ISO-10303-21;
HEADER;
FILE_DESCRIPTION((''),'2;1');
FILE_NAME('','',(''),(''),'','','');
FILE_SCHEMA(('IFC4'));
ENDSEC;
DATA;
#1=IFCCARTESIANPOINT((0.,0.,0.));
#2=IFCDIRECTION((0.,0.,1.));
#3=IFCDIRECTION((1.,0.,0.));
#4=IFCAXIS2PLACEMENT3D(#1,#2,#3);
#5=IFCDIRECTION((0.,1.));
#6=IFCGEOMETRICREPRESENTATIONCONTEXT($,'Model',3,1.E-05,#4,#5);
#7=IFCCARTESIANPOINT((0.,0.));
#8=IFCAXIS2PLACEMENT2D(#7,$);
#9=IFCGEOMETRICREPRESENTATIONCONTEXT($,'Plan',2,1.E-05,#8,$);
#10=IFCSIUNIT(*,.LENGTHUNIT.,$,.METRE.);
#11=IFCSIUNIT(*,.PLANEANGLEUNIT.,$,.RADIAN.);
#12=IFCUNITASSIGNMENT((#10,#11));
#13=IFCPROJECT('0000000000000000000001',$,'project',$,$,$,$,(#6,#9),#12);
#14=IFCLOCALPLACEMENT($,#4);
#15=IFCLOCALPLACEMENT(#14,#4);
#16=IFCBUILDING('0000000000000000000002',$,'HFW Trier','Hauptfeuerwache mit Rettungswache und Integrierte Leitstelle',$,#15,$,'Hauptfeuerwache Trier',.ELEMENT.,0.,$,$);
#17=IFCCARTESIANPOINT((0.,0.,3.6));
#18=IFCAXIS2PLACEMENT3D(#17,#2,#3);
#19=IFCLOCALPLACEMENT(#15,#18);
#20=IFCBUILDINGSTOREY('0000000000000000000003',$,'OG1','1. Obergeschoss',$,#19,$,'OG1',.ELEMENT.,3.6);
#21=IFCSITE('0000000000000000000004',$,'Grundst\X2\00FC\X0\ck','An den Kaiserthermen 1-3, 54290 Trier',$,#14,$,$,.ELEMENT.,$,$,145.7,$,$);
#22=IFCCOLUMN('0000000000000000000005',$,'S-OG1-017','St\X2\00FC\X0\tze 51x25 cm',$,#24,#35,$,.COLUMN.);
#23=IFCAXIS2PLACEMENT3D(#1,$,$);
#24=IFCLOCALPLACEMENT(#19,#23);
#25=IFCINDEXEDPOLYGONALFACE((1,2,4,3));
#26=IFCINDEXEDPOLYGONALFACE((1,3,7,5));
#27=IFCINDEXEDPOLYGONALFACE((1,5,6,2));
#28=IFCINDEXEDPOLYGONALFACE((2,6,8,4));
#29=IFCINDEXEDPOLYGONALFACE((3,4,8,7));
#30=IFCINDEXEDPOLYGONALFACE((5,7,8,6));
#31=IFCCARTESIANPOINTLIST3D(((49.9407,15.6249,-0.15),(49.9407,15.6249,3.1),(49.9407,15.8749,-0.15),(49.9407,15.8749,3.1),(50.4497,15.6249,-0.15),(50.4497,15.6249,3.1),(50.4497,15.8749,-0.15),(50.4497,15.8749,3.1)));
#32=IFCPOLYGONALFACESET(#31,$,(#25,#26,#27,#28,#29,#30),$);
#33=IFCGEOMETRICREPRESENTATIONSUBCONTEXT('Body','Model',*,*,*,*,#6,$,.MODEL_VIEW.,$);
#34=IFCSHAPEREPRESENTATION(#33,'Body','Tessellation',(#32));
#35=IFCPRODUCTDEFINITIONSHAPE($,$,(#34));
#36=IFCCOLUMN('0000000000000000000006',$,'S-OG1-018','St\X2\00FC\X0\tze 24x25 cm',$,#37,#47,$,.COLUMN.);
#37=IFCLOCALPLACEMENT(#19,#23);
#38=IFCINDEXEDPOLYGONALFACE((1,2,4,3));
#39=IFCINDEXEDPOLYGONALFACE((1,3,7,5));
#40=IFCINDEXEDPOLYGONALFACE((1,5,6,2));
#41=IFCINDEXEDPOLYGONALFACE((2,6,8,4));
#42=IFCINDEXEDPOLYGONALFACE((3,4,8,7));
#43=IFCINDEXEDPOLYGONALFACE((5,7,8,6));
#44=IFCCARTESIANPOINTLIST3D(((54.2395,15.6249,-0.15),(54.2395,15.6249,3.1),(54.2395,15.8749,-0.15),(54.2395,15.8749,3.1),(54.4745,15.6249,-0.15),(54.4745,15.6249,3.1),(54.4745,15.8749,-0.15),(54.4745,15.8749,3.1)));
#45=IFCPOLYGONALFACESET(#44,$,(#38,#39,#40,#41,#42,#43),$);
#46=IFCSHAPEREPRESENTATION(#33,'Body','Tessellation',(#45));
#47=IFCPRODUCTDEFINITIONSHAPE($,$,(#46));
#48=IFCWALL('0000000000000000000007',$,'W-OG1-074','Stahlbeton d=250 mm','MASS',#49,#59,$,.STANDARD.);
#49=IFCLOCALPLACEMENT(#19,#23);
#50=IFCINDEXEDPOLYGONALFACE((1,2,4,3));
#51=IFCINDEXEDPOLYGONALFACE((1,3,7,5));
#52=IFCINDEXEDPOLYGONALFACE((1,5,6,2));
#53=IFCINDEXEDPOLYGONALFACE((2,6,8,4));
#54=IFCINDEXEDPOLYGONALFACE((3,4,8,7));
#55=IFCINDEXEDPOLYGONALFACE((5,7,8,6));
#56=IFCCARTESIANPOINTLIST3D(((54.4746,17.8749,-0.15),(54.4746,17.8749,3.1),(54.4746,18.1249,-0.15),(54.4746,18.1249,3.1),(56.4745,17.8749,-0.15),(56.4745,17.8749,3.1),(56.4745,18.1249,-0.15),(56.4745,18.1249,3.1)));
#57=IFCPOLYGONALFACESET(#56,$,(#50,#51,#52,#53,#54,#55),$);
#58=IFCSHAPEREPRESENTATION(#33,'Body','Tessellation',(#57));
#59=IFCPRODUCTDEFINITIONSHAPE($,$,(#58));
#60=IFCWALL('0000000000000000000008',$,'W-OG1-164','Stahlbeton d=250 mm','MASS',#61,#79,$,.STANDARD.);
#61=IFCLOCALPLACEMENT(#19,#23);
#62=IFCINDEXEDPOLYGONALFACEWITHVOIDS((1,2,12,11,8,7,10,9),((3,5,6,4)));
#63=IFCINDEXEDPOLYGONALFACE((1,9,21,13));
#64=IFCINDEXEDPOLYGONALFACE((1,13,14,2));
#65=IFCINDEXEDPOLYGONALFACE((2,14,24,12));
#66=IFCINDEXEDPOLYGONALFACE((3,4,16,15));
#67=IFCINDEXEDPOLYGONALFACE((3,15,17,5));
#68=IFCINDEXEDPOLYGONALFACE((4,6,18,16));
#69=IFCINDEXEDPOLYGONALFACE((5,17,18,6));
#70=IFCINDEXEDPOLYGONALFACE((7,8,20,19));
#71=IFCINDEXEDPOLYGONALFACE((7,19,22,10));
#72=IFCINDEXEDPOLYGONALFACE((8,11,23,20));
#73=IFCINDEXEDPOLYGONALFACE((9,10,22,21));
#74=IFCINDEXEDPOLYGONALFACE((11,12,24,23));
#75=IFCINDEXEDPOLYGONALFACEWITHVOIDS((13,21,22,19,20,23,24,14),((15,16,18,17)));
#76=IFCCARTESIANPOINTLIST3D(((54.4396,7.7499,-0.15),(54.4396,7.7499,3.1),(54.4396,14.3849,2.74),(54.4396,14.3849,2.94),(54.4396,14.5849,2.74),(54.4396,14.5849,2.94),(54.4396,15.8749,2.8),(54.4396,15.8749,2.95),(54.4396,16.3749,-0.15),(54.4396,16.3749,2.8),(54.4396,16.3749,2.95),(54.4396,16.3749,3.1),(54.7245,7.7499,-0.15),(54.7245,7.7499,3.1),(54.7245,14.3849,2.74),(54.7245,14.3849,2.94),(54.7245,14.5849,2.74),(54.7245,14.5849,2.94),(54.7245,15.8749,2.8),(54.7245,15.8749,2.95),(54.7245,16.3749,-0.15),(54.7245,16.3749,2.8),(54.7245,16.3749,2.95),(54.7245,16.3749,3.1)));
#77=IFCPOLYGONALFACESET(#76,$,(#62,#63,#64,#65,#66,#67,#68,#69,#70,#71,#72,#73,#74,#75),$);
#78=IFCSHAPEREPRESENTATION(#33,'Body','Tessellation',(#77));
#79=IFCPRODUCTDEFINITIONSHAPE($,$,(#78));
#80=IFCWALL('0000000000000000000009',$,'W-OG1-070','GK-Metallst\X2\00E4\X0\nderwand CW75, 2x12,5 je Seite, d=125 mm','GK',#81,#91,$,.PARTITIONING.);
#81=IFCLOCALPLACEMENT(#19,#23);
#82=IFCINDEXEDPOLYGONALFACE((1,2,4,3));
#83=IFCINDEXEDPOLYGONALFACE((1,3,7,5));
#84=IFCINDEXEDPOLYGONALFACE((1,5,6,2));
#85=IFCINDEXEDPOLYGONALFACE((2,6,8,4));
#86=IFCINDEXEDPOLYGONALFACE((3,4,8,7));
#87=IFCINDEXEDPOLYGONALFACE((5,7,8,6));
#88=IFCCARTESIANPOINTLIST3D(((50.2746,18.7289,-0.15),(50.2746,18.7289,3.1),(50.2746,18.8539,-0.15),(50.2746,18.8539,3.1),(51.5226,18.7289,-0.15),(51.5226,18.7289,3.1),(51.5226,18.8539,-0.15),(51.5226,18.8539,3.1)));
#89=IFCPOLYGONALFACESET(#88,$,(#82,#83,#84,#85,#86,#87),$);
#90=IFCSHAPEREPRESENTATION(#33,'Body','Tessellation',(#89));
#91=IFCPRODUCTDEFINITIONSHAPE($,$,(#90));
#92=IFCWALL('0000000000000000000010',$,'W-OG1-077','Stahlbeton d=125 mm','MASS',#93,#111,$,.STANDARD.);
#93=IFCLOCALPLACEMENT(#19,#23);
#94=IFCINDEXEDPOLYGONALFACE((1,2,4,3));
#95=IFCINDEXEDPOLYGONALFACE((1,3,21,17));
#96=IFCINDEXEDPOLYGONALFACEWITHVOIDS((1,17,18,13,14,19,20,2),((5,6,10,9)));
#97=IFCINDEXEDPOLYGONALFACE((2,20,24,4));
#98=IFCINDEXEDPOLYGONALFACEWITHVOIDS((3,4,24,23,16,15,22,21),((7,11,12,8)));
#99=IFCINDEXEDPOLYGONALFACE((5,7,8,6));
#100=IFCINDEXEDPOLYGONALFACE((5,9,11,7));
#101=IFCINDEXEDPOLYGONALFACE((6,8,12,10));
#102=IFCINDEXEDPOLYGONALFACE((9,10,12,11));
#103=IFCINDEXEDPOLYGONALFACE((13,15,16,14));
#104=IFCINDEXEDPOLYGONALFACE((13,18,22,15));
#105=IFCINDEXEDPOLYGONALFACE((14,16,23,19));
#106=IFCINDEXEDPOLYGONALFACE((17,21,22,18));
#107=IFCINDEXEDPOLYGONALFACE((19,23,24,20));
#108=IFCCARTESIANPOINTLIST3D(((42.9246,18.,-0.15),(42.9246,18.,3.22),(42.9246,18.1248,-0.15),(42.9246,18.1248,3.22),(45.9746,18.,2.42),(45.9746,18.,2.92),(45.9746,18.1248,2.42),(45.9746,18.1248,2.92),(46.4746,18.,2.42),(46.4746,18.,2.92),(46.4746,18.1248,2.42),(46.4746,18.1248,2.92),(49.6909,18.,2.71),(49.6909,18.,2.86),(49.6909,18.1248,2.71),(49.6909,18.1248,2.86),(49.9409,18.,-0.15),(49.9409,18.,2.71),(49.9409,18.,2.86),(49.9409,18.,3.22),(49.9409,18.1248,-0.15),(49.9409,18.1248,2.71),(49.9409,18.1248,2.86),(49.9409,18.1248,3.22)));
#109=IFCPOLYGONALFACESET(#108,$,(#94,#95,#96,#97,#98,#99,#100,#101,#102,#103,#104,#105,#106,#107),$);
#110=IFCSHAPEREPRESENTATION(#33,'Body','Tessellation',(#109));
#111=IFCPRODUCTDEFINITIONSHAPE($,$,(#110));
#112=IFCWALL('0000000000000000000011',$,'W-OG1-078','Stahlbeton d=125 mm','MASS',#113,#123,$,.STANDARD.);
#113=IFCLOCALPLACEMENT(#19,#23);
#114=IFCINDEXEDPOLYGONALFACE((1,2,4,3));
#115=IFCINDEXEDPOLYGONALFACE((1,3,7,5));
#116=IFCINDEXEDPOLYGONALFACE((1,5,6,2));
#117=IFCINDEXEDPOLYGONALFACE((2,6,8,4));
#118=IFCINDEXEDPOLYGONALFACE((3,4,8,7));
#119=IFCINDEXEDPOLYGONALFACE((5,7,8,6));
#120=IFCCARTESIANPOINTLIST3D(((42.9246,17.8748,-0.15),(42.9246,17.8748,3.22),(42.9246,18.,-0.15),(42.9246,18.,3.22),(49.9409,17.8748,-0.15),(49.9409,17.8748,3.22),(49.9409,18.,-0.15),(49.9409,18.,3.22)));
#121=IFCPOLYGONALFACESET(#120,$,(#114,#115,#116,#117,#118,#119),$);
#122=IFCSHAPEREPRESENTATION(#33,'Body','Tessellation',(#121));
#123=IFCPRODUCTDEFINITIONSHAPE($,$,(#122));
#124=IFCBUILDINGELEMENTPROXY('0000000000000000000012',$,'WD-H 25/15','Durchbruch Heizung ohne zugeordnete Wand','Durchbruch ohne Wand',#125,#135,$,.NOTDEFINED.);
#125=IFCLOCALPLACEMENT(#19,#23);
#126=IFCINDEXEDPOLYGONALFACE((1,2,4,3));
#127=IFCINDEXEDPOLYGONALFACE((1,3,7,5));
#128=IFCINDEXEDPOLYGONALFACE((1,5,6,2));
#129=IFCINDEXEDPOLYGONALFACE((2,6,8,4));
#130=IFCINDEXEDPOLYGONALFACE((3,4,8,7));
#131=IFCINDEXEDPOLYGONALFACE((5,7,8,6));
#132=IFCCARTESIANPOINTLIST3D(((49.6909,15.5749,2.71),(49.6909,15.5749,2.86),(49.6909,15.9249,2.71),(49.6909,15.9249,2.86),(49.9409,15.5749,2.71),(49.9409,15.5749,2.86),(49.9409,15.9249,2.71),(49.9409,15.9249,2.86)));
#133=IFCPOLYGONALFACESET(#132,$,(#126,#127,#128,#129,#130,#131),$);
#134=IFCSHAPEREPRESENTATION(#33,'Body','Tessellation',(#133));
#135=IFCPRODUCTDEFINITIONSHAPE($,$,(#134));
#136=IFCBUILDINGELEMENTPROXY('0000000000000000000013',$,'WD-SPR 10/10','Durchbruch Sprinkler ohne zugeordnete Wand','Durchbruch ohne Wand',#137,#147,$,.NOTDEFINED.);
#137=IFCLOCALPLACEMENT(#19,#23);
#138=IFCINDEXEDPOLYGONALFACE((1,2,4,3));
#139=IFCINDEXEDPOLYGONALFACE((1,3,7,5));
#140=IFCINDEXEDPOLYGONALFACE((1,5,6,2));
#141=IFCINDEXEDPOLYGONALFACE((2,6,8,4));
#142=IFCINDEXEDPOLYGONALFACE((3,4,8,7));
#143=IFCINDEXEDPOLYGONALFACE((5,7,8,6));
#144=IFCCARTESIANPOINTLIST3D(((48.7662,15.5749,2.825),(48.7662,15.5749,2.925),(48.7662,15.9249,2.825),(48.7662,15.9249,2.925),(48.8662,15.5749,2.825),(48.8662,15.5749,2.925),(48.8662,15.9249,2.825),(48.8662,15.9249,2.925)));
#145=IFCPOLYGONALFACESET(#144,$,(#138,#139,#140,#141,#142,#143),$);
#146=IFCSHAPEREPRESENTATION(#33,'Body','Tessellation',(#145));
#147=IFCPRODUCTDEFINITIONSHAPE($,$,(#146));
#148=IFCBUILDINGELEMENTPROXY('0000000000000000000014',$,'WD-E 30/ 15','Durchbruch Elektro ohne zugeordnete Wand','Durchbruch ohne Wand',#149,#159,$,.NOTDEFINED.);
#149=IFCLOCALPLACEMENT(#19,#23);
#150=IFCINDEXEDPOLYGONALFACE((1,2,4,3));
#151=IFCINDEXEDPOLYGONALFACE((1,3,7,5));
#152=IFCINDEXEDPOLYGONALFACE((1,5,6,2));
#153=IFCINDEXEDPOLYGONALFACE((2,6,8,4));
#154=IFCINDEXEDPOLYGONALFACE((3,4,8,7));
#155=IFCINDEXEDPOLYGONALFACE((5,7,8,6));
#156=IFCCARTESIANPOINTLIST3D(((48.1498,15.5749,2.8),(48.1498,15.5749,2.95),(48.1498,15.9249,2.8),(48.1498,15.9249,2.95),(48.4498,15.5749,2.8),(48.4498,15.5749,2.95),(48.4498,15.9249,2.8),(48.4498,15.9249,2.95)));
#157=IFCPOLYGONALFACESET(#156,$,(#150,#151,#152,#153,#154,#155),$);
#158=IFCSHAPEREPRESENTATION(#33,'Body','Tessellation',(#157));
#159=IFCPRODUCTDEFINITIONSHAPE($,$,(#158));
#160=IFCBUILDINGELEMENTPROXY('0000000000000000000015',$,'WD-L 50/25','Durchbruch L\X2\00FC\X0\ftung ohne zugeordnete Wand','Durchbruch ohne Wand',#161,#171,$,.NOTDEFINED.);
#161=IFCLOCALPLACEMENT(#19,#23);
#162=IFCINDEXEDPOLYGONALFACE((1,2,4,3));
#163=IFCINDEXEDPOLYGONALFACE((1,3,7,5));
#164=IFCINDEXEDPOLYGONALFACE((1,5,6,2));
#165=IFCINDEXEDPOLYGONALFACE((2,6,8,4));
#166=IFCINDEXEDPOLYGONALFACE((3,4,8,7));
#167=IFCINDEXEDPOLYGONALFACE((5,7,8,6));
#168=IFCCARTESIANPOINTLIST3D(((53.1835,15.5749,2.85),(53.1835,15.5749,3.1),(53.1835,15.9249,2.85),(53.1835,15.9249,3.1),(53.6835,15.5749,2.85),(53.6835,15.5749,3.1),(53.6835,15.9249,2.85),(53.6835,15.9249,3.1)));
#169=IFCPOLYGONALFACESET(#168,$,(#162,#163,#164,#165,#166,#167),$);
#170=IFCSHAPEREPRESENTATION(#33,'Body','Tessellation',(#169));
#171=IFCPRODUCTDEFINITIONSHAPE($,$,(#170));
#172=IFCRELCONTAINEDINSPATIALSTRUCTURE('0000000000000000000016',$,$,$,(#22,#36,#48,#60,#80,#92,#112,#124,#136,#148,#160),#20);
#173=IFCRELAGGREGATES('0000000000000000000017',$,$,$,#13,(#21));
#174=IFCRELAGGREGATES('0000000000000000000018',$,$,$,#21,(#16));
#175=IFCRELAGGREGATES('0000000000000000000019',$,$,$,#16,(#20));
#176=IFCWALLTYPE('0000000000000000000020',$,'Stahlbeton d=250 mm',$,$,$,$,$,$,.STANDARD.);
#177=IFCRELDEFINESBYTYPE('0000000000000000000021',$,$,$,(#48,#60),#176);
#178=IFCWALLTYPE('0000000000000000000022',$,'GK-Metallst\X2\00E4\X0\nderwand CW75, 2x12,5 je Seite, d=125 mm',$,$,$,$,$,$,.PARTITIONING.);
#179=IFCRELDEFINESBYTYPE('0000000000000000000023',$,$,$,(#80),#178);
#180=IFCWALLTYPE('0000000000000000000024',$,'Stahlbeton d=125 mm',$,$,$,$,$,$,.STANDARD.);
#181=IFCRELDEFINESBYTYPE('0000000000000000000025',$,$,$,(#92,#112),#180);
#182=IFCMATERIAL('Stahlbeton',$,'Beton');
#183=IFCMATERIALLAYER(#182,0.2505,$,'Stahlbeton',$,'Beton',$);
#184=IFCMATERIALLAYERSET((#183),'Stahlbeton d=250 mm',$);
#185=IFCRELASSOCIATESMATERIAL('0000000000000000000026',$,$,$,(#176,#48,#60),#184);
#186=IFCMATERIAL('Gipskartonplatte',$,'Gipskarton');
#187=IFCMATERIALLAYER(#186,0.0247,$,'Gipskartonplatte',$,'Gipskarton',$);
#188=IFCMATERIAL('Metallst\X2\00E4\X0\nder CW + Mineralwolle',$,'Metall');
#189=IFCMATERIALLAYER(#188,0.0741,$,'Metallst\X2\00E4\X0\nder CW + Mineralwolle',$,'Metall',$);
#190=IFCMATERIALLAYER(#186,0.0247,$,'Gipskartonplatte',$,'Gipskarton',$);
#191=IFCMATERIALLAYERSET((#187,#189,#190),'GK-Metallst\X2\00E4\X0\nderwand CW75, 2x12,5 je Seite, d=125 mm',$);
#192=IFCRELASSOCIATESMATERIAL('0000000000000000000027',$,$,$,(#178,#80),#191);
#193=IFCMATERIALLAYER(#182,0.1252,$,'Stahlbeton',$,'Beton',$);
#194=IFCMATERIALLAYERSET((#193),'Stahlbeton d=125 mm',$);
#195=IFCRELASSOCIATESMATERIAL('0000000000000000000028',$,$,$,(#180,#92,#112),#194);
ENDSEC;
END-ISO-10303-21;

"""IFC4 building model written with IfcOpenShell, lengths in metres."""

from ifc_helpers import new_model, si_unit, direction, frame, frame_2d, origin_with_axes, origin_2d, place, context, subcontext, project, spatial, rectangle, extrude, material, layer, layer_set, layer_usage, type_object, element, save


model = new_model("IFC4")

# Units and contexts
model_context = context("Model", 3, precision=1e-05, world=origin_with_axes(), true_north=direction((0.0, 1.0)))
plan_context = context("Plan", 2, precision=1e-05, world=origin_2d())
body_context = subcontext(model_context, "Body", "Model", "MODEL_VIEW")
ifc_project = project(units=[si_unit("LENGTHUNIT", "METRE"), si_unit("PLANEANGLEUNIT", "RADIAN")], contexts=[model_context, plan_context])

# Site, building, storey
site_placement = place(None, origin_with_axes())
site = spatial("IfcSite", under=ifc_project, at=site_placement, Name="Grundstück", Description="An den Kaiserthermen 1-3, 54290 Trier", CompositionType="ELEMENT", RefElevation=145.7)
building_placement = place(site_placement, origin_with_axes())
building = spatial("IfcBuilding", under=site, at=building_placement, Name="HFW Trier", Description="Hauptfeuerwache mit Rettungswache und Integrierte Leitstelle", LongName="Hauptfeuerwache Trier", CompositionType="ELEMENT", ElevationOfRefHeight=0.0)
storey_placement = place(building_placement, frame((0.0, 0.0, 3.6), z_axis=(0.0, 0.0, 1.0), x_axis=(1.0, 0.0, 0.0)))
storey = spatial("IfcBuildingStorey", under=building, at=storey_placement, Name="OG1", Description="1. Obergeschoss", LongName="OG1", CompositionType="ELEMENT", Elevation=3.6)

# Columns
column_1_placement = place(storey_placement, frame((49.9407, 15.7499, -0.15), z_axis=(0.0, 0.0, 1.0), x_axis=(1.0, 0.0, 0.0)))
element("IfcColumn", 1, at=column_1_placement, inside=storey, Name="S-OG1-017", Description="Stütze 51x25 cm", PredefinedType="COLUMN", context=body_context, shape_type="SweptSolid", body=[
    extrude(rectangle(XDim=0.509, YDim=0.25, at=frame_2d((0.2545, 0.0))), origin_with_axes(), (0.0, 0.0, 1.0), 3.25),
])
column_2_placement = place(storey_placement, frame((54.2395, 15.7499, -0.15), z_axis=(0.0, 0.0, 1.0), x_axis=(1.0, 0.0, 0.0)))
element("IfcColumn", 2, at=column_2_placement, inside=storey, Name="S-OG1-018", Description="Stütze 24x25 cm", PredefinedType="COLUMN", context=body_context, shape_type="SweptSolid", body=[
    extrude(rectangle(XDim=0.235, YDim=0.25, at=frame_2d((0.1175, 0.0))), origin_with_axes(), (0.0, 0.0, 1.0), 3.25),
])

# Wall
ifc_material_1 = material(Name="Stahlbeton", Category="Beton")
ifc_layer_1 = layer(ifc_material_1, 0.2505, Name="Stahlbeton", Category="Beton")
ifc_layer_set_1 = layer_set([ifc_layer_1], Name="Stahlbeton d=250 mm")
ifc_layer_usage_1 = layer_usage(ifc_layer_set_1, "AXIS2", "POSITIVE", -0.125)
wall_type_1 = type_object("IfcWallType", Name="Stahlbeton d=250 mm", PredefinedType="STANDARD", material=ifc_layer_set_1)
wall_1_placement = place(storey_placement, frame((54.4746, 17.9999, -0.15), z_axis=(0.0, 0.0, 1.0), x_axis=(1.0, 0.0, 0.0)))
element("IfcWall", 3, at=wall_1_placement, inside=storey, type_object=wall_type_1, material=ifc_layer_usage_1, Name="W-OG1-074", Description="Stahlbeton d=250 mm", ObjectType="MASS", PredefinedType="STANDARD", context=body_context, shape_type="SweptSolid", body=[
    extrude(rectangle(XDim=1.9999, YDim=0.25, at=frame_2d((0.9999, 0.0))), origin_with_axes(), (0.0, 0.0, 1.0), 3.25),
])

# Wall, openings
ifc_layer_usage_2 = layer_usage(ifc_layer_set_1, "AXIS2", "POSITIVE", -0.1424)
wall_2_placement = place(storey_placement, frame((54.5821, 16.3749, -0.15), z_axis=(0.0, 0.0, 1.0), x_axis=(0.0, -1.0, 0.0)))
wall_2 = element("IfcWall", 4, at=wall_2_placement, inside=storey, type_object=wall_type_1, material=ifc_layer_usage_2, Name="W-OG1-164", Description="Stahlbeton d=250 mm", ObjectType="MASS", PredefinedType="STANDARD", context=body_context, shape_type="SweptSolid", body=[
    extrude(rectangle(XDim=8.625, YDim=0.2849, at=frame_2d((4.3125, 0.0))), origin_with_axes(), (0.0, 0.0, 1.0), 3.25),
])
opening_1_placement = place(wall_2_placement, origin_with_axes())
element("IfcOpeningElement", 5, at=opening_1_placement, cuts=wall_2, ObjectType="Wanddurchbruch", PredefinedType="OPENING", context=body_context, shape_type="SweptSolid", body=[
    extrude(rectangle(XDim=0.2, YDim=0.3849, at=frame_2d((1.89, 0.0))), frame((0.0, 0.0, 2.89), z_axis=(0.0, 0.0, 1.0), x_axis=(1.0, 0.0, 0.0)), (0.0, 0.0, 1.0), 0.2),
])
opening_2_placement = place(wall_2_placement, origin_with_axes())
element("IfcOpeningElement", 6, at=opening_2_placement, cuts=wall_2, ObjectType="Wanddurchbruch", PredefinedType="OPENING", context=body_context, shape_type="SweptSolid", body=[
    extrude(rectangle(XDim=0.5, YDim=0.3849, at=frame_2d((0.25, 0.0))), frame((0.0, 0.0, 2.95), z_axis=(0.0, 0.0, 1.0), x_axis=(1.0, 0.0, 0.0)), (0.0, 0.0, 1.0), 0.15),
])

# Wall
ifc_material_2 = material(Name="Gipskartonplatte", Category="Gipskarton")
ifc_layer_2 = layer(ifc_material_2, 0.0247, Name="Gipskartonplatte", Category="Gipskarton")
ifc_material_3 = material(Name="Metallständer CW + Mineralwolle", Category="Metall")
ifc_layer_3 = layer(ifc_material_3, 0.0741, Name="Metallständer CW + Mineralwolle", Category="Metall")
ifc_layer_4 = layer(ifc_material_2, 0.0247, Name="Gipskartonplatte", Category="Gipskarton")
ifc_layer_set_2 = layer_set([ifc_layer_2, ifc_layer_3, ifc_layer_4], Name="GK-Metallständerwand CW75, 2x12,5 je Seite, d=125 mm")
ifc_layer_usage_3 = layer_usage(ifc_layer_set_2, "AXIS2", "POSITIVE", -0.0625)
wall_type_2 = type_object("IfcWallType", Name="GK-Metallständerwand CW75, 2x12,5 je Seite, d=125 mm", PredefinedType="PARTITIONING", material=ifc_layer_set_2)
wall_3_placement = place(storey_placement, frame((50.2746, 18.7914, -0.15), z_axis=(0.0, 0.0, 1.0), x_axis=(1.0, 0.0, 0.0)))
element("IfcWall", 7, at=wall_3_placement, inside=storey, type_object=wall_type_2, material=ifc_layer_usage_3, Name="W-OG1-070", Description="GK-Metallständerwand CW75, 2x12,5 je Seite, d=125 mm", ObjectType="GK", PredefinedType="PARTITIONING", context=body_context, shape_type="SweptSolid", body=[
    extrude(rectangle(XDim=1.248, YDim=0.125, at=frame_2d((0.624, 0.0))), origin_with_axes(), (0.0, 0.0, 1.0), 3.25),
])

# Wall, openings
ifc_layer_5 = layer(ifc_material_1, 0.1252, Name="Stahlbeton", Category="Beton")
ifc_layer_set_3 = layer_set([ifc_layer_5], Name="Stahlbeton d=125 mm")
ifc_layer_usage_4 = layer_usage(ifc_layer_set_3, "AXIS2", "POSITIVE", -0.0624)
wall_type_3 = type_object("IfcWallType", Name="Stahlbeton d=125 mm", PredefinedType="STANDARD", material=ifc_layer_set_3)
wall_4_placement = place(storey_placement, frame((42.9246, 18.0624, -0.15), z_axis=(0.0, 0.0, 1.0), x_axis=(1.0, 0.0, 0.0)))
wall_4 = element("IfcWall", 8, at=wall_4_placement, inside=storey, type_object=wall_type_3, material=ifc_layer_usage_4, Name="W-OG1-077", Description="Stahlbeton d=125 mm", ObjectType="MASS", PredefinedType="STANDARD", context=body_context, shape_type="SweptSolid", body=[
    extrude(rectangle(XDim=7.0163, YDim=0.1249, at=frame_2d((3.5082, 0.0))), origin_with_axes(), (0.0, 0.0, 1.0), 3.37),
])
opening_3_placement = place(wall_4_placement, origin_with_axes())
element("IfcOpeningElement", 9, at=opening_3_placement, cuts=wall_4, ObjectType="Wanddurchbruch", PredefinedType="OPENING", context=body_context, shape_type="SweptSolid", body=[
    extrude(rectangle(XDim=0.25, YDim=0.2249, at=frame_2d((6.8913, 0.0))), frame((0.0, 0.0, 2.86), z_axis=(0.0, 0.0, 1.0), x_axis=(1.0, 0.0, 0.0)), (0.0, 0.0, 1.0), 0.15),
])
opening_4_placement = place(wall_4_placement, origin_with_axes())
element("IfcOpeningElement", 10, at=opening_4_placement, cuts=wall_4, ObjectType="Wanddurchbruch", PredefinedType="OPENING", context=body_context, shape_type="SweptSolid", body=[
    extrude(rectangle(XDim=0.5, YDim=0.2249, at=frame_2d((3.3, 0.0))), frame((0.0, 0.0, 2.57), z_axis=(0.0, 0.0, 1.0), x_axis=(1.0, 0.0, 0.0)), (0.0, 0.0, 1.0), 0.5),
])

# Wall
ifc_layer_usage_5 = layer_usage(ifc_layer_set_3, "AXIS2", "POSITIVE", -0.0625)
wall_5_placement = place(storey_placement, frame((42.9246, 17.9374, -0.15), z_axis=(0.0, 0.0, 1.0), x_axis=(1.0, 0.0, 0.0)))
element("IfcWall", 11, at=wall_5_placement, inside=storey, type_object=wall_type_3, material=ifc_layer_usage_5, Name="W-OG1-078", Description="Stahlbeton d=125 mm", ObjectType="MASS", PredefinedType="STANDARD", context=body_context, shape_type="SweptSolid", body=[
    extrude(rectangle(XDim=7.0163, YDim=0.1251, at=frame_2d((3.5082, 0.0))), origin_with_axes(), (0.0, 0.0, 1.0), 3.37),
])

# Building element proxies
proxy_1_placement = place(storey_placement, frame((49.8159, 15.7499, 2.71), z_axis=(0.0, 0.0, 1.0), x_axis=(1.0, 0.0, 0.0)))
element("IfcBuildingElementProxy", 12, at=proxy_1_placement, inside=storey, Name="WD-H 25/15", Description="Durchbruch Heizung ohne zugeordnete Wand", ObjectType="Durchbruch ohne Wand", PredefinedType="NOTDEFINED", context=body_context, shape_type="SweptSolid", body=[
    extrude(rectangle(XDim=0.25, YDim=0.35, at=origin_2d()), origin_with_axes(), (0.0, 0.0, 1.0), 0.15),
])
proxy_2_placement = place(storey_placement, frame((48.8162, 15.7499, 2.825), z_axis=(0.0, 0.0, 1.0), x_axis=(1.0, 0.0, 0.0)))
element("IfcBuildingElementProxy", 13, at=proxy_2_placement, inside=storey, Name="WD-SPR 10/10", Description="Durchbruch Sprinkler ohne zugeordnete Wand", ObjectType="Durchbruch ohne Wand", PredefinedType="NOTDEFINED", context=body_context, shape_type="SweptSolid", body=[
    extrude(rectangle(XDim=0.1, YDim=0.35, at=origin_2d()), origin_with_axes(), (0.0, 0.0, 1.0), 0.1),
])
proxy_3_placement = place(storey_placement, frame((48.2998, 15.7499, 2.8), z_axis=(0.0, 0.0, 1.0), x_axis=(1.0, 0.0, 0.0)))
element("IfcBuildingElementProxy", 14, at=proxy_3_placement, inside=storey, Name="WD-E 30/ 15", Description="Durchbruch Elektro ohne zugeordnete Wand", ObjectType="Durchbruch ohne Wand", PredefinedType="NOTDEFINED", context=body_context, shape_type="SweptSolid", body=[
    extrude(rectangle(XDim=0.3, YDim=0.35, at=origin_2d()), origin_with_axes(), (0.0, 0.0, 1.0), 0.15),
])
proxy_4_placement = place(storey_placement, frame((53.4335, 15.7499, 2.85), z_axis=(0.0, 0.0, 1.0), x_axis=(1.0, 0.0, 0.0)))
element("IfcBuildingElementProxy", 15, at=proxy_4_placement, inside=storey, Name="WD-L 50/25", Description="Durchbruch Lüftung ohne zugeordnete Wand", ObjectType="Durchbruch ohne Wand", PredefinedType="NOTDEFINED", context=body_context, shape_type="SweptSolid", body=[
    extrude(rectangle(XDim=0.5, YDim=0.35, at=origin_2d()), origin_with_axes(), (0.0, 0.0, 1.0), 0.25),
])

save(model, "model.ifc")
